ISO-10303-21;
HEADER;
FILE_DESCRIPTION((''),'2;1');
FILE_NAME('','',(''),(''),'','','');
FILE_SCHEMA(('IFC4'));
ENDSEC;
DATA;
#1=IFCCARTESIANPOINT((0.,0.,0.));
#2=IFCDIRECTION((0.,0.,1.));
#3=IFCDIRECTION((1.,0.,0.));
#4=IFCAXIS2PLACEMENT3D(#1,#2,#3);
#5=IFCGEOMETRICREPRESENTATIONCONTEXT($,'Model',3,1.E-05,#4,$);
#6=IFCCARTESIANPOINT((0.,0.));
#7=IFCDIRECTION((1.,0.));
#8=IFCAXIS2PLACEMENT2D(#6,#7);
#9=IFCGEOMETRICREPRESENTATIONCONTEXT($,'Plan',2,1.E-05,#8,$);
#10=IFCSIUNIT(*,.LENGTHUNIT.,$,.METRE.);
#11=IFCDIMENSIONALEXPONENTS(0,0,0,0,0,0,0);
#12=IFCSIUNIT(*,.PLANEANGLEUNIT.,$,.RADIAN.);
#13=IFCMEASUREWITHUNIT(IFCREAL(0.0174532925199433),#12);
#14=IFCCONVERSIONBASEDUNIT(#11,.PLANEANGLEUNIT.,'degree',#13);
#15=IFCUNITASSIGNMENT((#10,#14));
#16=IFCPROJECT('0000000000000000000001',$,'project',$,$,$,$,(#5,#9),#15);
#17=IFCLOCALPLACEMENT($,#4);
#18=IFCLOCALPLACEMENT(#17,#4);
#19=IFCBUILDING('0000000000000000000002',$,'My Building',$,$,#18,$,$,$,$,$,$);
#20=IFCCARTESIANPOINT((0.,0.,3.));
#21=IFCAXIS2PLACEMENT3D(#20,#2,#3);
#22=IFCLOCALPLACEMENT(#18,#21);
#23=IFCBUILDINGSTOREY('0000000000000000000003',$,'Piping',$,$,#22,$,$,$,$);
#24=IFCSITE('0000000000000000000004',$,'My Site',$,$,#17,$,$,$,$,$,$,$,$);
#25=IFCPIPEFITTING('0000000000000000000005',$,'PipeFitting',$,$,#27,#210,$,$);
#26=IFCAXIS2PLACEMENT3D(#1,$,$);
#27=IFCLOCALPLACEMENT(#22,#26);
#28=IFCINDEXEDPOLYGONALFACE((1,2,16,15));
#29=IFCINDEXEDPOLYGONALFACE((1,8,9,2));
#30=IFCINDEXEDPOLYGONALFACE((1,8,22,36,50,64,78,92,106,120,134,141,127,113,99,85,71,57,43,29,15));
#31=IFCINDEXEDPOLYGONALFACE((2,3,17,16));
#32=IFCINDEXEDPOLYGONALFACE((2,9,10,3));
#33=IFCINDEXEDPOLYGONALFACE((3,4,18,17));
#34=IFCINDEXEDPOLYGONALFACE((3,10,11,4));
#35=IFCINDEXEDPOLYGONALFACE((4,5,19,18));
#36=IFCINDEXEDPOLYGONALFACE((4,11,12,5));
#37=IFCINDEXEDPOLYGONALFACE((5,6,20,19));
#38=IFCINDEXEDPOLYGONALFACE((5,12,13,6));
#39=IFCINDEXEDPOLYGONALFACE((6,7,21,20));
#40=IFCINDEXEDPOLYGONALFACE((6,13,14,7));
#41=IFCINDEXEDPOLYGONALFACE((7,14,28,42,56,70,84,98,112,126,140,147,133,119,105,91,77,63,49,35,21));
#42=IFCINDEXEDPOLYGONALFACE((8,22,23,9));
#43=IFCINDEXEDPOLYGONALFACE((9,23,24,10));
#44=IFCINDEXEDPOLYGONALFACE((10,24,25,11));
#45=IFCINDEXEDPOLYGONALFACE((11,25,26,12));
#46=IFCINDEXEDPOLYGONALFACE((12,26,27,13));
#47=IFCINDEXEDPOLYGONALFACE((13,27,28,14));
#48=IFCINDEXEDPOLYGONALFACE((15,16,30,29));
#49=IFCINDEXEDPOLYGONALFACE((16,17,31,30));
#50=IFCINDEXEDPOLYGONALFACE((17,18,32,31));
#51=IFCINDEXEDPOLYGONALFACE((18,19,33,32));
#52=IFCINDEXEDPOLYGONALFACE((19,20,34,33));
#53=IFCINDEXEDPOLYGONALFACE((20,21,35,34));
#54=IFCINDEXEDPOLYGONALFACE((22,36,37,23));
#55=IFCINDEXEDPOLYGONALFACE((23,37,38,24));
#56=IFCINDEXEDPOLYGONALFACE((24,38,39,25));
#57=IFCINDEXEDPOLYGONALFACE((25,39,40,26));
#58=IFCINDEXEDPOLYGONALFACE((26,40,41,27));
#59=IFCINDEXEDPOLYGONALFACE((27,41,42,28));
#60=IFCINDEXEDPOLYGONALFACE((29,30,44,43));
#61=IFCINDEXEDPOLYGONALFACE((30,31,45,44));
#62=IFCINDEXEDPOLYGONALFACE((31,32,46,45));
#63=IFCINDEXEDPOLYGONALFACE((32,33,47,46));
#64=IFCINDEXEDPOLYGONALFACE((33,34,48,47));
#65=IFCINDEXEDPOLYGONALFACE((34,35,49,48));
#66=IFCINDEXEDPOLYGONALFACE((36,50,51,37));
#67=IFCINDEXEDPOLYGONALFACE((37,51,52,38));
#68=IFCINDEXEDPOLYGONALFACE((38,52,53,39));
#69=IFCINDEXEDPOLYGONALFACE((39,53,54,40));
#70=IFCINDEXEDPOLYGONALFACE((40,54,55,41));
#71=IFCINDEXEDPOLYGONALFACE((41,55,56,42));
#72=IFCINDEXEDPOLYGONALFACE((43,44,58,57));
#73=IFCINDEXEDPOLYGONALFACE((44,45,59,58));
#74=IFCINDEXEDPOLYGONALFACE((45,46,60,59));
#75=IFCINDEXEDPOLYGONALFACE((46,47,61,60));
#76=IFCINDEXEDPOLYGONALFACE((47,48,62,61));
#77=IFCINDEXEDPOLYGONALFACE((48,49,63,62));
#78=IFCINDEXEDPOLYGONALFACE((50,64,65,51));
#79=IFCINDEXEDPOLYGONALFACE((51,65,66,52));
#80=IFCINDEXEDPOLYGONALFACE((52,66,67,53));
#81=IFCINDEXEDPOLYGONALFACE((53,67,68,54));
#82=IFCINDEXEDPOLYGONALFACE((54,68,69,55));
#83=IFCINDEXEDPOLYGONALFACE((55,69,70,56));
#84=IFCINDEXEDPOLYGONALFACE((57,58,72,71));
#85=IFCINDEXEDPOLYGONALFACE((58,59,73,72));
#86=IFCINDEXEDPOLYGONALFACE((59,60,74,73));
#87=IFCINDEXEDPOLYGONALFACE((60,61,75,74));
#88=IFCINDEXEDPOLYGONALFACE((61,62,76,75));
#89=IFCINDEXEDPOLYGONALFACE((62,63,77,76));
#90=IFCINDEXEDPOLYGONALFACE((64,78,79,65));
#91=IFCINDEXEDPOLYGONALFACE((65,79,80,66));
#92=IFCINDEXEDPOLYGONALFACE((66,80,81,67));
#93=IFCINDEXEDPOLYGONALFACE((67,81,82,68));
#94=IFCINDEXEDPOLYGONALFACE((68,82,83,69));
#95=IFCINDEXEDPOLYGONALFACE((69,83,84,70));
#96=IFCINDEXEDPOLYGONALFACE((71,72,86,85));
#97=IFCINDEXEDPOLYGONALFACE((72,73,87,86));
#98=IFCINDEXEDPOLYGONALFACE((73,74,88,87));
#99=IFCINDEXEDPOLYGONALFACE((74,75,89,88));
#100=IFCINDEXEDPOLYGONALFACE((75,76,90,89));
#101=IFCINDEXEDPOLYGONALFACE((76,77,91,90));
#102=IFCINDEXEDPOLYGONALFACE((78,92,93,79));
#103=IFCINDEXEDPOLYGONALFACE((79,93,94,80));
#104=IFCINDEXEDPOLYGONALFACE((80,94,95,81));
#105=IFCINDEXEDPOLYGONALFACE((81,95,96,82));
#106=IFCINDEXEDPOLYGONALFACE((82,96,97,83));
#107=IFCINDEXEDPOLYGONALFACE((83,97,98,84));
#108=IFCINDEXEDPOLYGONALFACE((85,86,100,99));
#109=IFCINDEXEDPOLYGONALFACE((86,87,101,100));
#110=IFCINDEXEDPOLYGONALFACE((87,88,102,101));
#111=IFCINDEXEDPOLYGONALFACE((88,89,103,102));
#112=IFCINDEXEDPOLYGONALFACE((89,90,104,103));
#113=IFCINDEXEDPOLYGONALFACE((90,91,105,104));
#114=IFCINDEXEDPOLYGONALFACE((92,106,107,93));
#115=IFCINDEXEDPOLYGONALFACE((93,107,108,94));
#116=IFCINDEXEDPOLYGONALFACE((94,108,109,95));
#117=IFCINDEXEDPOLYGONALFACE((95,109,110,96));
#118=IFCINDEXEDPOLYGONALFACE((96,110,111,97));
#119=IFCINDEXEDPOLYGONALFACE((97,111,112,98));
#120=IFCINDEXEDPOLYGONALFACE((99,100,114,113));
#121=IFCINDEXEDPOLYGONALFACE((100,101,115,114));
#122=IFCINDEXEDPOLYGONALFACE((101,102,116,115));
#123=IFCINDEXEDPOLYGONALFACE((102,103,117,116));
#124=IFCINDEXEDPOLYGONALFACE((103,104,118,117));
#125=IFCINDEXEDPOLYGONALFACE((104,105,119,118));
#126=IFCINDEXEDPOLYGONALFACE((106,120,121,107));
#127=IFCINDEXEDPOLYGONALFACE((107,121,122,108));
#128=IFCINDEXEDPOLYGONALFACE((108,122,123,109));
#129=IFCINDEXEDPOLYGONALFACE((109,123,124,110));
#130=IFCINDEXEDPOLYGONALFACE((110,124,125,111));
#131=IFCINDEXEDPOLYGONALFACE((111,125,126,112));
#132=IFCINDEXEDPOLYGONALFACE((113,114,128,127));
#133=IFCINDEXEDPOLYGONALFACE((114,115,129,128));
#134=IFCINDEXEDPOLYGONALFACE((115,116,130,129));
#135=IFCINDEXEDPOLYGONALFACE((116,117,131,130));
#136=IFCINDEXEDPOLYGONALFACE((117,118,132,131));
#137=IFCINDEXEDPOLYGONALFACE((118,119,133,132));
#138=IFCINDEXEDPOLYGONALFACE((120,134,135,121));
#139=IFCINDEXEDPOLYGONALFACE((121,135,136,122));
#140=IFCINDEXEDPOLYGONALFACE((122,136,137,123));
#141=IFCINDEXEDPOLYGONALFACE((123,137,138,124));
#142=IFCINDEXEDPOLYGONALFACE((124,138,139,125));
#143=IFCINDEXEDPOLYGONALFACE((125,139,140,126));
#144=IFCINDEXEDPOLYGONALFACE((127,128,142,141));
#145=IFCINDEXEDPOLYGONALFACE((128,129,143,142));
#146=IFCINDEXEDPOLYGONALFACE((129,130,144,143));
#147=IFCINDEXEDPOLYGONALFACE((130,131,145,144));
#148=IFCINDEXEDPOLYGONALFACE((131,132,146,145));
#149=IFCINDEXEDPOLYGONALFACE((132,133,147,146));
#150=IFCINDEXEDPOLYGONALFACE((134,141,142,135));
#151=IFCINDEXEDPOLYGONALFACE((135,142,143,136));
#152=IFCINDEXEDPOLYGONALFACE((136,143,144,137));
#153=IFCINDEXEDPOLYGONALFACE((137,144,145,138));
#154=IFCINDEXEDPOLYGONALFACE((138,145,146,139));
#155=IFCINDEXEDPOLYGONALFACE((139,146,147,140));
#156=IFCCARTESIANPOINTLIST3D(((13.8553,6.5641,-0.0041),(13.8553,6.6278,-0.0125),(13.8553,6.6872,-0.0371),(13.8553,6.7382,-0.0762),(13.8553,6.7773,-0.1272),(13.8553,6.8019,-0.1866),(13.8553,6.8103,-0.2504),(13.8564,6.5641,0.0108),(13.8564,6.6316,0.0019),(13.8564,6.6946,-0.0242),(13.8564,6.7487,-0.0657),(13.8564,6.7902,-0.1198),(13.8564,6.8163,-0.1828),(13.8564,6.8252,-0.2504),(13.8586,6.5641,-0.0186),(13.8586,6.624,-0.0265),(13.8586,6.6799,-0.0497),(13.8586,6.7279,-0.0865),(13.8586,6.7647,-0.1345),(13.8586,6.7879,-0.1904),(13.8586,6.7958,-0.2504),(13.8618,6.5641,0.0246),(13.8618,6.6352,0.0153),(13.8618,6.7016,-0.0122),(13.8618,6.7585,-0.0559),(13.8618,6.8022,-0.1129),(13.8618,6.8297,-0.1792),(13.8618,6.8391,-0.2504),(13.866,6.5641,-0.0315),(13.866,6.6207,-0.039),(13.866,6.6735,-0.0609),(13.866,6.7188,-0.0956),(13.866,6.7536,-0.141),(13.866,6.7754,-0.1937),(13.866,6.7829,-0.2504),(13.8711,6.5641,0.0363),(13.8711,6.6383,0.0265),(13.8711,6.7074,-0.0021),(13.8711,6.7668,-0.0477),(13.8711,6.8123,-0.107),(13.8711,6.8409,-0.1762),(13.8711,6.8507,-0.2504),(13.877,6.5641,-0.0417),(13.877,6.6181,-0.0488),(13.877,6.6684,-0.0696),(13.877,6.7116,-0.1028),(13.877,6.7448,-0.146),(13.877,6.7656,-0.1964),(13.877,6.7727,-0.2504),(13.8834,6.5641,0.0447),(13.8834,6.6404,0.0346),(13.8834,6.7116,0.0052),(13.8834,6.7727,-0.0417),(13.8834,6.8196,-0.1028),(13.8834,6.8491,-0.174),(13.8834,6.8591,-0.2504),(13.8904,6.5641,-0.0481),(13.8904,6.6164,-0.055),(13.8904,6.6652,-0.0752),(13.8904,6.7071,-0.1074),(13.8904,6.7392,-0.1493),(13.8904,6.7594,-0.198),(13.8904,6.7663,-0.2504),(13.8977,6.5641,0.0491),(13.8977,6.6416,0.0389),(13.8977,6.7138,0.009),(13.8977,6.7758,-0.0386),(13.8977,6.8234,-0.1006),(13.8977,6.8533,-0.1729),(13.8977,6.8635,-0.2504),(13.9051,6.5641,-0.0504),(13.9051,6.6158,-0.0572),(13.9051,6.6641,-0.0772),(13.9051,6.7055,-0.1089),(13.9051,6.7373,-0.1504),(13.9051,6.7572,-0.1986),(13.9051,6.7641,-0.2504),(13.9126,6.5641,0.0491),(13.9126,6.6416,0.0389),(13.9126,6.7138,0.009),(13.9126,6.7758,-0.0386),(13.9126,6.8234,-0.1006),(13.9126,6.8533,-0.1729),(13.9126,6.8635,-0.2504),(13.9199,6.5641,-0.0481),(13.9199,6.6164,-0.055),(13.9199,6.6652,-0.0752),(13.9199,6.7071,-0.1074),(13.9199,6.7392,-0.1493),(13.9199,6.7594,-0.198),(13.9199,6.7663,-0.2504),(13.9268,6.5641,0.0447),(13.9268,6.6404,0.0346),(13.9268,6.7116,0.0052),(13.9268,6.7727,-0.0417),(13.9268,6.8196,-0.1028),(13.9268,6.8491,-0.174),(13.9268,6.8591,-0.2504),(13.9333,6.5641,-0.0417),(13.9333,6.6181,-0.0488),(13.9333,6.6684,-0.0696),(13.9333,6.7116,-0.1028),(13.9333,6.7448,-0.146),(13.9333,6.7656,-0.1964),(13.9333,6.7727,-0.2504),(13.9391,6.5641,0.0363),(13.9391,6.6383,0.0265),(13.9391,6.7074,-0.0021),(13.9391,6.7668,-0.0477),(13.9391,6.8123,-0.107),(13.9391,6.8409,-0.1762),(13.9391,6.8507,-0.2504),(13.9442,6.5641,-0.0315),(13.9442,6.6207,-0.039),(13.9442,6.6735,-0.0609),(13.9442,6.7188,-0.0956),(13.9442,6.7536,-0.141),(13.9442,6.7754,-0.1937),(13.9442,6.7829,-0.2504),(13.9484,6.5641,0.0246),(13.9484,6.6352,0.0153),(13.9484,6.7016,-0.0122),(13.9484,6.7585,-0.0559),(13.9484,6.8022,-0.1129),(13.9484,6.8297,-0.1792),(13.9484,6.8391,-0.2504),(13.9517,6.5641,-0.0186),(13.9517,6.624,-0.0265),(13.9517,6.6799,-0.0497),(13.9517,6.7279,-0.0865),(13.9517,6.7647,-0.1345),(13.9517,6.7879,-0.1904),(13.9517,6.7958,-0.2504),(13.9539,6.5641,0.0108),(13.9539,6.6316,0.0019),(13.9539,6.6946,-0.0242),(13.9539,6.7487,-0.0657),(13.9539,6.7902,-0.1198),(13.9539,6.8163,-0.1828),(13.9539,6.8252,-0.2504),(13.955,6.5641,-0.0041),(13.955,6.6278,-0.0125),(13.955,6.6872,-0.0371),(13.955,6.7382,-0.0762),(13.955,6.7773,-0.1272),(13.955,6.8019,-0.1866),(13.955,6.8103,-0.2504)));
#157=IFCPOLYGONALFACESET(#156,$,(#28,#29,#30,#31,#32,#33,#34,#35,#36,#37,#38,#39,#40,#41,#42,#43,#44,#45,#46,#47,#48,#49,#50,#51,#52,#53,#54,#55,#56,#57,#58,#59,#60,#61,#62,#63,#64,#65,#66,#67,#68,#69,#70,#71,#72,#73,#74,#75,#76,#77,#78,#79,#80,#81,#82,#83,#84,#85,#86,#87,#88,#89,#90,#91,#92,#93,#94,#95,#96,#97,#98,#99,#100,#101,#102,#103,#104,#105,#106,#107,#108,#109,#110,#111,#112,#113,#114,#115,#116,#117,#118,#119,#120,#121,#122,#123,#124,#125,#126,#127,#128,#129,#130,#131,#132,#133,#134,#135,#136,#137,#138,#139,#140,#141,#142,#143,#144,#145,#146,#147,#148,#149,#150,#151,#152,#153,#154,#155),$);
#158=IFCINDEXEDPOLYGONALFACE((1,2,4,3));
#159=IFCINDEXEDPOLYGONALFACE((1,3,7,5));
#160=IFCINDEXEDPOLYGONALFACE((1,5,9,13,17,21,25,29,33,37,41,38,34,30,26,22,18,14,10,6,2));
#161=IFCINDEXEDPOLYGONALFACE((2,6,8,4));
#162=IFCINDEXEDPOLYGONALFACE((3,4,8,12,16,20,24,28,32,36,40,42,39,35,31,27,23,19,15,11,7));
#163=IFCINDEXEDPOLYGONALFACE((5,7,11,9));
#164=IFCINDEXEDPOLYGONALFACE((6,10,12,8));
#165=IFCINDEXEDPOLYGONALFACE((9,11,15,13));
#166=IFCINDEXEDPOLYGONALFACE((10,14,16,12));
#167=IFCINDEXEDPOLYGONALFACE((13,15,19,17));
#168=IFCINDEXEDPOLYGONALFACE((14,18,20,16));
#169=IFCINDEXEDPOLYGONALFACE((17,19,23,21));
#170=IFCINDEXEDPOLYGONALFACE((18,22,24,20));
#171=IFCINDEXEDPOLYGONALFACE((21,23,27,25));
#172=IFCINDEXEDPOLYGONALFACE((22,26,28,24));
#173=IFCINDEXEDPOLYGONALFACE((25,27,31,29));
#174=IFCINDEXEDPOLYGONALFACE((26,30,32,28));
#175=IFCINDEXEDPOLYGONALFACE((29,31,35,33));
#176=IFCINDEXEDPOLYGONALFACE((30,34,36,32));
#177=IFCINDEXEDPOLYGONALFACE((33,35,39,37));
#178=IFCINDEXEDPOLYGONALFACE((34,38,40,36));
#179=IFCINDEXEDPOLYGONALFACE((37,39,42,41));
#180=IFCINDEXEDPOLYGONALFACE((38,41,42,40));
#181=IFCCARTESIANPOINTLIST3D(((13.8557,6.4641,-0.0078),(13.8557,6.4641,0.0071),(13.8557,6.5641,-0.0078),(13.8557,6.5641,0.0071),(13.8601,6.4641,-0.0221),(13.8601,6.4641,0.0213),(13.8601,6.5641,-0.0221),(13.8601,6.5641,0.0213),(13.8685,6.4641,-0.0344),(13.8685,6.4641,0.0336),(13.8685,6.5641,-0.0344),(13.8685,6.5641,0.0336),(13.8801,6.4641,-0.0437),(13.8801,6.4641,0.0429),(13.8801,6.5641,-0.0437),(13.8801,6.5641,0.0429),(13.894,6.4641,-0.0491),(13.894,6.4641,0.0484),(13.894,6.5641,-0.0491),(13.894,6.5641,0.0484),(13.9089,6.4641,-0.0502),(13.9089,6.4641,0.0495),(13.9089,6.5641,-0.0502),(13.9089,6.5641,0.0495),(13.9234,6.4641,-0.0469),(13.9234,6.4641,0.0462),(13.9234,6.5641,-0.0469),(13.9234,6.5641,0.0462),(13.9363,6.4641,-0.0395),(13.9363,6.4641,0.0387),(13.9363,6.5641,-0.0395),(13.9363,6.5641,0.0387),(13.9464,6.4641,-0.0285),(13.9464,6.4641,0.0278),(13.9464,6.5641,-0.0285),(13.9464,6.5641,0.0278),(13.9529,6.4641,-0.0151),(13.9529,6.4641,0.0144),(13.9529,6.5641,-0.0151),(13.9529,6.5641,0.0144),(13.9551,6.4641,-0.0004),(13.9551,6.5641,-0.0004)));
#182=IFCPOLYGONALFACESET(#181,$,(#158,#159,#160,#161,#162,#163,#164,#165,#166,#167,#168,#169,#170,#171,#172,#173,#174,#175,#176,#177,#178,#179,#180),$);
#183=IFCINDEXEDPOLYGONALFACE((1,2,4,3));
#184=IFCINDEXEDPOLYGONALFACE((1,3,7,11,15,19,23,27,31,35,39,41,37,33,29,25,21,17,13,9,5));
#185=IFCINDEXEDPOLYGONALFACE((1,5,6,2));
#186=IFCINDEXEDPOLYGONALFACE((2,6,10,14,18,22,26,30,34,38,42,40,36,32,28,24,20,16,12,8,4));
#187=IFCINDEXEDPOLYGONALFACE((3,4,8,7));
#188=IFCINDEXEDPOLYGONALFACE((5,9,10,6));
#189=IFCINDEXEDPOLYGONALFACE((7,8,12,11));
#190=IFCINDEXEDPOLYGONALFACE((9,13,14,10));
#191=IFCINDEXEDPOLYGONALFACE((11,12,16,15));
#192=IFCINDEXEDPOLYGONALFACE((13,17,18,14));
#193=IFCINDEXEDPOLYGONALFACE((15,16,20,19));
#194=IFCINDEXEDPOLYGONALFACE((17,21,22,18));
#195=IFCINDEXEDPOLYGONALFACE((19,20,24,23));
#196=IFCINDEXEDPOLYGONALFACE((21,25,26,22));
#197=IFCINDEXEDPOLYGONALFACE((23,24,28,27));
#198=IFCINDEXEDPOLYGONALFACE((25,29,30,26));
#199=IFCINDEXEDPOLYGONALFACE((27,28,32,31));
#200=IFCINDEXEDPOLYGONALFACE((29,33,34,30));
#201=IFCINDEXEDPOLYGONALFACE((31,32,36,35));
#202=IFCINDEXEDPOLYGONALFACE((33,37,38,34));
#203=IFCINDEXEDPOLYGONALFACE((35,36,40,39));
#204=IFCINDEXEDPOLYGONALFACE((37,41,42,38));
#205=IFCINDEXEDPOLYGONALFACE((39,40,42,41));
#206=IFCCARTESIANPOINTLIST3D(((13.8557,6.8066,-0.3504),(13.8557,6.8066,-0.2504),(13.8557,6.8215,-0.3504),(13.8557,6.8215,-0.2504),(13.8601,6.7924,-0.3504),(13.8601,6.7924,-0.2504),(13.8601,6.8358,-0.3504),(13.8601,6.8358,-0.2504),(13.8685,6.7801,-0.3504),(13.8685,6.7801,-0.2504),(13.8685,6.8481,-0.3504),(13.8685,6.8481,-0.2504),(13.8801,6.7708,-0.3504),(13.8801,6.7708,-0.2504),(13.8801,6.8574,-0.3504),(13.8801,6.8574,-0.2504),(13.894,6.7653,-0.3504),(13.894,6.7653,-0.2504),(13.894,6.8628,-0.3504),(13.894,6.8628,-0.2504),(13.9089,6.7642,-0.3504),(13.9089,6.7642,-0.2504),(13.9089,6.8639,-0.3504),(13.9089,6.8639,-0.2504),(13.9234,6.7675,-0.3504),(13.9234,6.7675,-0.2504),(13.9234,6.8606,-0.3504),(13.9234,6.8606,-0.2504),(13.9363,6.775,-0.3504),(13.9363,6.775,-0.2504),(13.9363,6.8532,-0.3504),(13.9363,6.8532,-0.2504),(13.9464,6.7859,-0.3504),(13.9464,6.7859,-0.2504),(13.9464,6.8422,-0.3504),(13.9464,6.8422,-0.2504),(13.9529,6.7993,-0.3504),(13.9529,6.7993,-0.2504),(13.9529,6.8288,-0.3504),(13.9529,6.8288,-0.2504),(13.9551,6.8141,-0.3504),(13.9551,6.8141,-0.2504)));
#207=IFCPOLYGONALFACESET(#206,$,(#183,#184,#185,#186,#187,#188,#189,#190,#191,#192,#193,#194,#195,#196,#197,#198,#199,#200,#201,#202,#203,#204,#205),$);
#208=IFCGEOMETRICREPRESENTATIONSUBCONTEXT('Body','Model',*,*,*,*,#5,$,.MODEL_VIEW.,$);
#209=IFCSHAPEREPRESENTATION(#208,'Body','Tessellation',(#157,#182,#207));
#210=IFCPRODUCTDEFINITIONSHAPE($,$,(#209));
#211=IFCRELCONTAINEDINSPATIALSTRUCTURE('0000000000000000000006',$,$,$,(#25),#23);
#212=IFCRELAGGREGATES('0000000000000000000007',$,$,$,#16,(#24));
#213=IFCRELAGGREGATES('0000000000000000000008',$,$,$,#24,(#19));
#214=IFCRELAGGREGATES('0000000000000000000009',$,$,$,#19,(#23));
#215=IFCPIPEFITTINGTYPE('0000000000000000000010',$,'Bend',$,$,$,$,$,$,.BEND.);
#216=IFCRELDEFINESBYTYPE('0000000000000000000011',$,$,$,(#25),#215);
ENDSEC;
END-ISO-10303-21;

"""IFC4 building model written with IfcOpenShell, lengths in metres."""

from ifc_helpers import new_model, entity, si_unit, converted_unit, frame, origin_with_axes, origin_2d_with_axis, place, context, subcontext, project, spatial, circle, extrude, source, transform, mapped, type_object, type_shapes, element, save


model = new_model("IFC4")

# Units and contexts
model_context = context("Model", 3, precision=1e-05, world=origin_with_axes())
plan_context = context("Plan", 2, precision=1e-05, world=origin_2d_with_axis())
body_context = subcontext(model_context, "Body", "Model", "MODEL_VIEW")
ifc_project = project(units=[si_unit("LENGTHUNIT", "METRE"), converted_unit("PLANEANGLEUNIT", "degree", entity("IfcReal", 0.0174532925199433), si_unit("PLANEANGLEUNIT", "RADIAN"), dimensions=[0, 0, 0, 0, 0, 0, 0])], contexts=[model_context, plan_context])

# Site, building, storey
site_placement = place(None, origin_with_axes())
site = spatial("IfcSite", under=ifc_project, at=site_placement, Name="My Site")
building_placement = place(site_placement, origin_with_axes())
building = spatial("IfcBuilding", under=site, at=building_placement, Name="My Building")
storey_placement = place(building_placement, frame((0.0, 0.0, 3.0), z_axis=(0.0, 0.0, 1.0), x_axis=(1.0, 0.0, 0.0)))
storey = spatial("IfcBuildingStorey", under=building, at=storey_placement, Name="Piping")

# Shared definitions
pipe_fitting_type = type_object("IfcPipeFittingType", Name="Bend", PredefinedType="BEND")
shared_shape = source(origin_with_axes(), body_context, "Body", "SolidModel", [
    entity("IfcSweptDiskSolid", entity("IfcIndexedPolyCurve", entity("IfcCartesianPointList3D", [[0.0, 0.0, -0.1], [0.0, -0.0732, -0.2768], [0.0, -0.25, -0.35]]), [entity("IfcArcIndex", [1, 2, 3])]), 0.05),
    extrude(circle(Radius=0.05), origin_with_axes(), (0.0, 0.0, -1.0), 0.1),
    extrude(circle(Radius=0.05), frame((0.0, -0.25, -0.35), z_axis=(0.0, -1.0, 0.0), x_axis=(1.0, 0.0, 0.0)), (0.0, 0.0, 1.0), 0.1),
])
type_shapes(pipe_fitting_type, [shared_shape])

# Pipe fitting
for number, where, z_axis, x_axis, name in (
    (1, (13.9051, 6.4641, -0.0004), (0.0, -1.0, 0.0), (1.0, 0.0, 0.0), "PipeFitting"),
):
    element("IfcPipeFitting", number, at=place(storey_placement, frame(where, z_axis=z_axis, x_axis=x_axis)), inside=storey, type_object=pipe_fitting_type, Name=name, context=body_context, shape_type="MappedRepresentation", body=[
        mapped(shared_shape, transform((0.0, 0.0, 0.0), x_axis=(1.0, 0.0, 0.0), y_axis=(0.0, 1.0, 0.0), z_axis=(0.0, 0.0, 1.0), scale=1.0)),
    ])

save(model, "model.ifc")
